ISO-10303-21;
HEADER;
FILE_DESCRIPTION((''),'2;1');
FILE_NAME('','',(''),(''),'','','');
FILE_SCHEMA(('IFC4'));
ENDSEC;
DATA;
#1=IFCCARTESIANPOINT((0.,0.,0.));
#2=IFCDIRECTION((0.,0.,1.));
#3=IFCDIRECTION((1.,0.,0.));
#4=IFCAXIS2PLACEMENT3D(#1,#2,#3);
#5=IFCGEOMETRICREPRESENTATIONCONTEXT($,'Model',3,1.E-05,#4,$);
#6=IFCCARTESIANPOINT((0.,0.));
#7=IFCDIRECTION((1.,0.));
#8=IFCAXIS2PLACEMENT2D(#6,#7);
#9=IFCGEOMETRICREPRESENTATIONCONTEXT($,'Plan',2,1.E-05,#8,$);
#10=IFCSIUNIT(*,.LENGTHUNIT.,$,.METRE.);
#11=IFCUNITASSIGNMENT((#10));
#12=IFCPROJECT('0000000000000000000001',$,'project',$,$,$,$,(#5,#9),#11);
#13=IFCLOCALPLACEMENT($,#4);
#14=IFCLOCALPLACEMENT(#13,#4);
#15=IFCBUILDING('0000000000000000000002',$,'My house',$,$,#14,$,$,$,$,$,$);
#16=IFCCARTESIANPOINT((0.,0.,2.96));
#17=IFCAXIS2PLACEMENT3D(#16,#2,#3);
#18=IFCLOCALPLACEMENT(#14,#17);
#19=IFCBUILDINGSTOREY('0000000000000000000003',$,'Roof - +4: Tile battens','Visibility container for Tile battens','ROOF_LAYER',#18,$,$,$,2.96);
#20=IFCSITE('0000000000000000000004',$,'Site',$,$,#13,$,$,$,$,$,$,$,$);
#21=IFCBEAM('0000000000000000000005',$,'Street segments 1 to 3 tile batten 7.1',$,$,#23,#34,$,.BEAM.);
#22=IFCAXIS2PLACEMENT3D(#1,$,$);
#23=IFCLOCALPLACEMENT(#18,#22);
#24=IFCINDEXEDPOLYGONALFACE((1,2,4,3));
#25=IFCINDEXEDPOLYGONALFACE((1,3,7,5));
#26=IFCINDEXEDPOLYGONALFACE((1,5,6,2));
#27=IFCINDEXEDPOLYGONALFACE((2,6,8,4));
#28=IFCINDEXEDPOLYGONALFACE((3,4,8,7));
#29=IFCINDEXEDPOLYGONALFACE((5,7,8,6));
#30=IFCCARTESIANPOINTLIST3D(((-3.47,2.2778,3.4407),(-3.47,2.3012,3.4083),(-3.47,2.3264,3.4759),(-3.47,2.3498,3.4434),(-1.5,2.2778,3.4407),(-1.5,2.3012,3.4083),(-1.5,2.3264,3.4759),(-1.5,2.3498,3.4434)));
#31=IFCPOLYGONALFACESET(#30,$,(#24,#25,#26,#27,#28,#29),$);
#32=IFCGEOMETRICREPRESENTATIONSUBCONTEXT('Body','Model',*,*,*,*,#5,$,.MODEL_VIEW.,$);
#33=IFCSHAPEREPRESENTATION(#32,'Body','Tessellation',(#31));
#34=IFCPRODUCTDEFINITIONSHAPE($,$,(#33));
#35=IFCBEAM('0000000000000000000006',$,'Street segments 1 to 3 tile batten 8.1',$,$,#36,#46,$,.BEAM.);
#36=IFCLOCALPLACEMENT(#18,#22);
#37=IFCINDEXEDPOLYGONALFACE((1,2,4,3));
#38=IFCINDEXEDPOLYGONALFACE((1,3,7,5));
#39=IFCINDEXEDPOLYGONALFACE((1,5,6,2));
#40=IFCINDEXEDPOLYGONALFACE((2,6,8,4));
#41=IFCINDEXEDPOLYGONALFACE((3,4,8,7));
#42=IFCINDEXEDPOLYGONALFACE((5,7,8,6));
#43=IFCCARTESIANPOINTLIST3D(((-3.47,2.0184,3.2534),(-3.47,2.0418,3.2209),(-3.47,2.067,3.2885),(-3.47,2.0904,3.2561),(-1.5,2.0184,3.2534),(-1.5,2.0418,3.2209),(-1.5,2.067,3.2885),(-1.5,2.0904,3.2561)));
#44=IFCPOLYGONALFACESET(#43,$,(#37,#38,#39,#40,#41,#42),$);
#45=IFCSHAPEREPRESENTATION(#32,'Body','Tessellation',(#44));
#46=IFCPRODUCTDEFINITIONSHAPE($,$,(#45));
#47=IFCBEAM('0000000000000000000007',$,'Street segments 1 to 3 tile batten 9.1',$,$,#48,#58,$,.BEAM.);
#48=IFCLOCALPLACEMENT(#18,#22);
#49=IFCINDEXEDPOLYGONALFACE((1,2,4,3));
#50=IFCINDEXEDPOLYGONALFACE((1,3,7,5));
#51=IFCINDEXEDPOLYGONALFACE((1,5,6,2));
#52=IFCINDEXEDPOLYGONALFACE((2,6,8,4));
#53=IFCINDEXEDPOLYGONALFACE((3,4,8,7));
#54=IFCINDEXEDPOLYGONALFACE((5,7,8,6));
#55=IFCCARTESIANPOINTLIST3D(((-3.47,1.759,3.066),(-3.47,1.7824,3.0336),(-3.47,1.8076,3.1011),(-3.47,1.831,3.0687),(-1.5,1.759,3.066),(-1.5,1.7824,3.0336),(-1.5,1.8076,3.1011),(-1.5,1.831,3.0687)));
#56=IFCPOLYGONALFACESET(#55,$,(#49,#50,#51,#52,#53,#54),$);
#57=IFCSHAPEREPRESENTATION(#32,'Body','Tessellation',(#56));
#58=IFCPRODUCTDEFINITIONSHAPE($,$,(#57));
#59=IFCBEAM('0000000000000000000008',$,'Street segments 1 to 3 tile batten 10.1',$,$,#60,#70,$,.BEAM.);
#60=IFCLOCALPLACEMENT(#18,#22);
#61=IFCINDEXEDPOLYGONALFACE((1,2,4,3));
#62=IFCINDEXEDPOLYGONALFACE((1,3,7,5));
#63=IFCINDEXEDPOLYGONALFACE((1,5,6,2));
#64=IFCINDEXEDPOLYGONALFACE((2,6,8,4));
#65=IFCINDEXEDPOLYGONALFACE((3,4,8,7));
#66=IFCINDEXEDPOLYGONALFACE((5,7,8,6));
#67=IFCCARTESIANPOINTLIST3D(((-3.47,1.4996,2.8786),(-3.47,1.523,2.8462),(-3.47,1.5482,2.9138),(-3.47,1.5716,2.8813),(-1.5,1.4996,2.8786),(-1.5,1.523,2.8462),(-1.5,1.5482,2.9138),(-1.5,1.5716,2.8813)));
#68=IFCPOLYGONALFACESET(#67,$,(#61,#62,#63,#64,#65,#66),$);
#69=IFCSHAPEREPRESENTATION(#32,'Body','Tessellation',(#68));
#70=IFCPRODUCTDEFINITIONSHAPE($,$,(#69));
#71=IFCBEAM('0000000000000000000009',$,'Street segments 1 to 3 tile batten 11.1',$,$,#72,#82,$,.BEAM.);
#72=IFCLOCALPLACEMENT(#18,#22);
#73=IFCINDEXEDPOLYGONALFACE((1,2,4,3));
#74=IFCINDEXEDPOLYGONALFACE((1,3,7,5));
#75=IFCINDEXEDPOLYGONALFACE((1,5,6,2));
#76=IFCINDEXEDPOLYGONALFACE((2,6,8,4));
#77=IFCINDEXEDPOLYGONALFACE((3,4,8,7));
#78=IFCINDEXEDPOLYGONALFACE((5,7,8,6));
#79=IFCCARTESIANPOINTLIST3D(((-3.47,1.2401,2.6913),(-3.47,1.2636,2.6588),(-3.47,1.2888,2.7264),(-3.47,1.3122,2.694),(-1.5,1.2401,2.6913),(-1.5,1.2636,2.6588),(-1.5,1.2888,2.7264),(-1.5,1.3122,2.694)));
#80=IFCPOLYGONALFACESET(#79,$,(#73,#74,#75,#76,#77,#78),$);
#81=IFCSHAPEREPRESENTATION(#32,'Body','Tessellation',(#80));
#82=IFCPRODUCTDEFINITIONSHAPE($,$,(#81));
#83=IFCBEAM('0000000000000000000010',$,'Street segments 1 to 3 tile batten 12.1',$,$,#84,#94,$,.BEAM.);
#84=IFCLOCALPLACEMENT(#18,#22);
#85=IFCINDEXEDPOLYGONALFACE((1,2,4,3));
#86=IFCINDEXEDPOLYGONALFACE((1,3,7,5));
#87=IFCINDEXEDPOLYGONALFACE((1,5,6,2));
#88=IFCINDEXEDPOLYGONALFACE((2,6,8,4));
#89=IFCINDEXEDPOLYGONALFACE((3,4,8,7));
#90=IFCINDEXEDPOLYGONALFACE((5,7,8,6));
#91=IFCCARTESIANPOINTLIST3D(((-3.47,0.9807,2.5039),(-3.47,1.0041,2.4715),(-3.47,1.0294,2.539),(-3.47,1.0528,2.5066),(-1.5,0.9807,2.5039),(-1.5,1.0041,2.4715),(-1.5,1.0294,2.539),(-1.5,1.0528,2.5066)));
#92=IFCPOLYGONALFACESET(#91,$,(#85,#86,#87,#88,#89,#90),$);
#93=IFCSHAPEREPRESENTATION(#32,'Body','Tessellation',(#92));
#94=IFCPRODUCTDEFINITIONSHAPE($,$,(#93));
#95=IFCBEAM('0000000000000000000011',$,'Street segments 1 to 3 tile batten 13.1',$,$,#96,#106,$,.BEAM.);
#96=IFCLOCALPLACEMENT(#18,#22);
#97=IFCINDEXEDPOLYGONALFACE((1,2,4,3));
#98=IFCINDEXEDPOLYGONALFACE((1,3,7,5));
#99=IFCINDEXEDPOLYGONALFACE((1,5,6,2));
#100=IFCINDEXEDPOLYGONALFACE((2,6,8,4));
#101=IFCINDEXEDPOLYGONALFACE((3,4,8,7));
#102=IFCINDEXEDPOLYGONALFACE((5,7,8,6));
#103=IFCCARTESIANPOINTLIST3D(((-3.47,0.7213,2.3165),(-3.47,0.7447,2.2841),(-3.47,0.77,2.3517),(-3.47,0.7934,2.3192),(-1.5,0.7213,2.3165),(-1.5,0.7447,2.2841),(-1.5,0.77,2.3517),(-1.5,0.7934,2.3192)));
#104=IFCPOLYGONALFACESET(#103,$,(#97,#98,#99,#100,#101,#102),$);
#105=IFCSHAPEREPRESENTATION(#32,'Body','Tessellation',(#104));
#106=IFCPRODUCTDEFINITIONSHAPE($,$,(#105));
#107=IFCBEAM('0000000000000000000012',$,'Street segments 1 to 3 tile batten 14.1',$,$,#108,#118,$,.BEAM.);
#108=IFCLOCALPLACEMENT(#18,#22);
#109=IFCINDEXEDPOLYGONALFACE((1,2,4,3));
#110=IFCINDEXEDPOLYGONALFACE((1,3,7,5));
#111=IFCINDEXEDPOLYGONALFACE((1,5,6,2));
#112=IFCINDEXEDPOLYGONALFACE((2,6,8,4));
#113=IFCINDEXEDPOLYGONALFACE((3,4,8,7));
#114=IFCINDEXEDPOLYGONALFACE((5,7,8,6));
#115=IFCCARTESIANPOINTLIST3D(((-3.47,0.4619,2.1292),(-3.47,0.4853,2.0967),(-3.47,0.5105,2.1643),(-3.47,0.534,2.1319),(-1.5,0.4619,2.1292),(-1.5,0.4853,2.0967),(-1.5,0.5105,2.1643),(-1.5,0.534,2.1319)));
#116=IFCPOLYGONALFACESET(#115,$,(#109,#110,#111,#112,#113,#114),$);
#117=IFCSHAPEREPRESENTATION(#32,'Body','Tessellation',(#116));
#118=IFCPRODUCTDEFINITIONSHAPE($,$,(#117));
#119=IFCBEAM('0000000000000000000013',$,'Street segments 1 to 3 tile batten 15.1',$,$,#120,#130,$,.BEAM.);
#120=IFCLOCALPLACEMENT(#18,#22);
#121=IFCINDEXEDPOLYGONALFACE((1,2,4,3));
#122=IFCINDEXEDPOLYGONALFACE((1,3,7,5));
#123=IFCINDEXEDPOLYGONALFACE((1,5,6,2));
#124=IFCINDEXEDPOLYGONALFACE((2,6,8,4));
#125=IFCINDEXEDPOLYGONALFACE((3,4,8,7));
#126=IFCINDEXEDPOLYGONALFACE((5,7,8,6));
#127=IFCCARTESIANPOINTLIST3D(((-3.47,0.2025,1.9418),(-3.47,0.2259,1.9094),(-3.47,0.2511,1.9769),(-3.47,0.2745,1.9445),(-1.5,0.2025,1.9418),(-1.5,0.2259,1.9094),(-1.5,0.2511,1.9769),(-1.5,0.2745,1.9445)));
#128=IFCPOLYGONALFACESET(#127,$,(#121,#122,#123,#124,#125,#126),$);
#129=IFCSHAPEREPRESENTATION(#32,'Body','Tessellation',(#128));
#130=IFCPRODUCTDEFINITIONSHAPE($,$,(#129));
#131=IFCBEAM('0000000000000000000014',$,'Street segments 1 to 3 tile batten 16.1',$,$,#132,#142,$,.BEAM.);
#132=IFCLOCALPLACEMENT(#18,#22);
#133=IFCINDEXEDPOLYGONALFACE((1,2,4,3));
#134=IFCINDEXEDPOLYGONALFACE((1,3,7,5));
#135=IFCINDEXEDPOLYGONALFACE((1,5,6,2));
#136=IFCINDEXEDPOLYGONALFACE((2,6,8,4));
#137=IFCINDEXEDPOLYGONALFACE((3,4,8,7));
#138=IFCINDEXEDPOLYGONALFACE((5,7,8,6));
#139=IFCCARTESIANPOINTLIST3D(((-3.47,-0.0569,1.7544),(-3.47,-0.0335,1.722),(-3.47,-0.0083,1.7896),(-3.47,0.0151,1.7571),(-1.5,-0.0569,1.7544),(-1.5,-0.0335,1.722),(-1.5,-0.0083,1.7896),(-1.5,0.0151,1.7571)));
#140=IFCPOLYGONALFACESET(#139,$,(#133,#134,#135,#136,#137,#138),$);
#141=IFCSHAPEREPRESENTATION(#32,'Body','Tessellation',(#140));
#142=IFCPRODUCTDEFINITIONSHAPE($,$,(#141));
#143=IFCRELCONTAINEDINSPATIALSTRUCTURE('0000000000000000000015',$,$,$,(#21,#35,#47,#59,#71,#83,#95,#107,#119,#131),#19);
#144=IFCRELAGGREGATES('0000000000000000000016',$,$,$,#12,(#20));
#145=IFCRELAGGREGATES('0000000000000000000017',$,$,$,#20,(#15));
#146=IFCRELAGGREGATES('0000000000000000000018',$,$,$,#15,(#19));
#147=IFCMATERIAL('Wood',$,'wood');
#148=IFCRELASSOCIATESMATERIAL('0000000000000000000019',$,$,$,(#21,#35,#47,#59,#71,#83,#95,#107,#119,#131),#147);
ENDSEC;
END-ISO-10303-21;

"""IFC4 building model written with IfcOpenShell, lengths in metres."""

from ifc_helpers import new_model, si_unit, frame, origin_with_axes, origin_2d_with_axis, place, context, subcontext, project, spatial, rectangle, extrude, clip, halfspace, source, transform, mapped, material, element, save


model = new_model("IFC4")

# Units and contexts
model_context = context("Model", 3, precision=1e-05, world=origin_with_axes())
plan_context = context("Plan", 2, precision=1e-05, world=origin_2d_with_axis())
body_context = subcontext(model_context, "Body", "Model", "MODEL_VIEW")
ifc_project = project(units=[si_unit("LENGTHUNIT", "METRE")], contexts=[model_context, plan_context])

# Site, building, storey
site_placement = place(None, origin_with_axes())
site = spatial("IfcSite", under=ifc_project, at=site_placement, Name="Site")
building_placement = place(site_placement, origin_with_axes())
building = spatial("IfcBuilding", under=site, at=building_placement, Name="My house")
storey_placement = place(building_placement, frame((0.0, 0.0, 2.96), z_axis=(0.0, 0.0, 1.0), x_axis=(1.0, 0.0, 0.0)))
storey = spatial("IfcBuildingStorey", under=building, at=storey_placement, Name="Roof - +4: Tile battens", Description="Visibility container for Tile battens", ObjectType="ROOF_LAYER", Elevation=2.96)

# Beams
ifc_material = material(Name="Wood", Category="wood")
shared_shape_1 = source(origin_with_axes(), body_context, "Body", "Clipping", [
    clip(clip(extrude(rectangle(XDim=0.06, YDim=0.04), frame((0.0, 0.0, 0.0), z_axis=(1.0, 0.0, 0.0), x_axis=(0.0, 1.0, 0.0)), (0.0, 0.0, 1.0), 1.97), halfspace(frame((-1.5, -2.3816, -6.1772), z_axis=(0.0, 0.810664, -0.585512), x_axis=(1.0, 0.0, 0.0)), False)), halfspace(frame((-1.5, -6.2322, -3.396), z_axis=(0.0, -0.810664, 0.585512), x_axis=(-1.0, 0.0, 0.0)), False)),
])
beam_1_placement = place(storey_placement, frame((-1.5, 2.3138, 3.4421), z_axis=(0.0, -0.585512, 0.810664), x_axis=(1.0, 0.0, 0.0)))
element("IfcBeam", 1, at=beam_1_placement, inside=storey, material=ifc_material, Name="Street segments 1 to 3 tile batten 7.1", PredefinedType="BEAM", context=body_context, shape_type="MappedRepresentation", body=[
    mapped(shared_shape_1, transform((0.0, 0.0, 0.0), x_axis=(-1.0, 0.0, 0.0), y_axis=(0.0, 1.0, 0.0), z_axis=(0.0, 0.0, 1.0), scale=1.0)),
])
shared_shape_2 = source(origin_with_axes(), body_context, "Body", "Clipping", [
    clip(clip(extrude(rectangle(XDim=0.06, YDim=0.04), frame((0.0, 0.0, 0.0), z_axis=(1.0, 0.0, 0.0), x_axis=(0.0, 1.0, 0.0)), (0.0, 0.0, 1.0), 1.97), halfspace(frame((-1.5, -2.0616, -6.1772), z_axis=(0.0, 0.810664, -0.585512), x_axis=(1.0, 0.0, 0.0)), False)), halfspace(frame((-1.5, -5.9122, -3.396), z_axis=(0.0, -0.810664, 0.585512), x_axis=(-1.0, 0.0, 0.0)), False)),
])
beam_2_placement = place(storey_placement, frame((-1.5, 2.0544, 3.2547), z_axis=(0.0, -0.585512, 0.810664), x_axis=(1.0, 0.0, 0.0)))
element("IfcBeam", 2, at=beam_2_placement, inside=storey, material=ifc_material, Name="Street segments 1 to 3 tile batten 8.1", PredefinedType="BEAM", context=body_context, shape_type="MappedRepresentation", body=[
    mapped(shared_shape_2, transform((0.0, 0.0, 0.0), x_axis=(-1.0, 0.0, 0.0), y_axis=(0.0, 1.0, 0.0), z_axis=(0.0, 0.0, 1.0), scale=1.0)),
])
shared_shape_3 = source(origin_with_axes(), body_context, "Body", "Clipping", [
    clip(clip(extrude(rectangle(XDim=0.06, YDim=0.04), frame((0.0, 0.0, 0.0), z_axis=(1.0, 0.0, 0.0), x_axis=(0.0, 1.0, 0.0)), (0.0, 0.0, 1.0), 1.97), halfspace(frame((-1.5, -1.7416, -6.1772), z_axis=(0.0, 0.810664, -0.585512), x_axis=(1.0, 0.0, 0.0)), False)), halfspace(frame((-1.5, -5.5922, -3.396), z_axis=(0.0, -0.810664, 0.585512), x_axis=(-1.0, 0.0, 0.0)), False)),
])
beam_3_placement = place(storey_placement, frame((-1.5, 1.795, 3.0673), z_axis=(0.0, -0.585512, 0.810664), x_axis=(1.0, 0.0, 0.0)))
element("IfcBeam", 3, at=beam_3_placement, inside=storey, material=ifc_material, Name="Street segments 1 to 3 tile batten 9.1", PredefinedType="BEAM", context=body_context, shape_type="MappedRepresentation", body=[
    mapped(shared_shape_3, transform((0.0, 0.0, 0.0), x_axis=(-1.0, 0.0, 0.0), y_axis=(0.0, 1.0, 0.0), z_axis=(0.0, 0.0, 1.0), scale=1.0)),
])
shared_shape_4 = source(origin_with_axes(), body_context, "Body", "Clipping", [
    clip(clip(extrude(rectangle(XDim=0.06, YDim=0.04), frame((0.0, 0.0, 0.0), z_axis=(1.0, 0.0, 0.0), x_axis=(0.0, 1.0, 0.0)), (0.0, 0.0, 1.0), 1.97), halfspace(frame((-1.5, -1.4216, -6.1772), z_axis=(0.0, 0.810664, -0.585512), x_axis=(1.0, 0.0, 0.0)), False)), halfspace(frame((-1.5, -5.2722, -3.396), z_axis=(0.0, -0.810664, 0.585512), x_axis=(-1.0, 0.0, 0.0)), False)),
])
beam_4_placement = place(storey_placement, frame((-1.5, 1.5356, 2.88), z_axis=(0.0, -0.585512, 0.810664), x_axis=(1.0, 0.0, 0.0)))
element("IfcBeam", 4, at=beam_4_placement, inside=storey, material=ifc_material, Name="Street segments 1 to 3 tile batten 10.1", PredefinedType="BEAM", context=body_context, shape_type="MappedRepresentation", body=[
    mapped(shared_shape_4, transform((0.0, 0.0, 0.0), x_axis=(-1.0, 0.0, 0.0), y_axis=(0.0, 1.0, 0.0), z_axis=(0.0, 0.0, 1.0), scale=1.0)),
])
shared_shape_5 = source(origin_with_axes(), body_context, "Body", "Clipping", [
    clip(clip(extrude(rectangle(XDim=0.06, YDim=0.04), frame((0.0, 0.0, 0.0), z_axis=(1.0, 0.0, 0.0), x_axis=(0.0, 1.0, 0.0)), (0.0, 0.0, 1.0), 1.97), halfspace(frame((-1.5, -1.1016, -6.1772), z_axis=(0.0, 0.810664, -0.585512), x_axis=(1.0, 0.0, 0.0)), False)), halfspace(frame((-1.5, -4.9522, -3.396), z_axis=(0.0, -0.810664, 0.585512), x_axis=(-1.0, 0.0, 0.0)), False)),
])
beam_5_placement = place(storey_placement, frame((-1.5, 1.2762, 2.6926), z_axis=(0.0, -0.585512, 0.810664), x_axis=(1.0, 0.0, 0.0)))
element("IfcBeam", 5, at=beam_5_placement, inside=storey, material=ifc_material, Name="Street segments 1 to 3 tile batten 11.1", PredefinedType="BEAM", context=body_context, shape_type="MappedRepresentation", body=[
    mapped(shared_shape_5, transform((0.0, 0.0, 0.0), x_axis=(-1.0, 0.0, 0.0), y_axis=(0.0, 1.0, 0.0), z_axis=(0.0, 0.0, 1.0), scale=1.0)),
])
shared_shape_6 = source(origin_with_axes(), body_context, "Body", "Clipping", [
    clip(clip(extrude(rectangle(XDim=0.06, YDim=0.04), frame((0.0, 0.0, 0.0), z_axis=(1.0, 0.0, 0.0), x_axis=(0.0, 1.0, 0.0)), (0.0, 0.0, 1.0), 1.97), halfspace(frame((-1.5, -0.7816, -6.1772), z_axis=(0.0, 0.810664, -0.585512), x_axis=(1.0, 0.0, 0.0)), False)), halfspace(frame((-1.5, -4.6322, -3.396), z_axis=(0.0, -0.810664, 0.585512), x_axis=(-1.0, 0.0, 0.0)), False)),
])
beam_6_placement = place(storey_placement, frame((-1.5, 1.0168, 2.5053), z_axis=(0.0, -0.585512, 0.810664), x_axis=(1.0, 0.0, 0.0)))
element("IfcBeam", 6, at=beam_6_placement, inside=storey, material=ifc_material, Name="Street segments 1 to 3 tile batten 12.1", PredefinedType="BEAM", context=body_context, shape_type="MappedRepresentation", body=[
    mapped(shared_shape_6, transform((0.0, 0.0, 0.0), x_axis=(-1.0, 0.0, 0.0), y_axis=(0.0, 1.0, 0.0), z_axis=(0.0, 0.0, 1.0), scale=1.0)),
])
shared_shape_7 = source(origin_with_axes(), body_context, "Body", "Clipping", [
    clip(clip(extrude(rectangle(XDim=0.06, YDim=0.04), frame((0.0, 0.0, 0.0), z_axis=(1.0, 0.0, 0.0), x_axis=(0.0, 1.0, 0.0)), (0.0, 0.0, 1.0), 1.97), halfspace(frame((-1.5, -0.4616, -6.1772), z_axis=(0.0, 0.810664, -0.585512), x_axis=(1.0, 0.0, 0.0)), False)), halfspace(frame((-1.5, -4.3122, -3.396), z_axis=(0.0, -0.810664, 0.585512), x_axis=(-1.0, 0.0, 0.0)), False)),
])
beam_7_placement = place(storey_placement, frame((-1.5, 0.7573, 2.3179), z_axis=(0.0, -0.585512, 0.810664), x_axis=(1.0, 0.0, 0.0)))
element("IfcBeam", 7, at=beam_7_placement, inside=storey, material=ifc_material, Name="Street segments 1 to 3 tile batten 13.1", PredefinedType="BEAM", context=body_context, shape_type="MappedRepresentation", body=[
    mapped(shared_shape_7, transform((0.0, 0.0, 0.0), x_axis=(-1.0, 0.0, 0.0), y_axis=(0.0, 1.0, 0.0), z_axis=(0.0, 0.0, 1.0), scale=1.0)),
])
shared_shape_8 = source(origin_with_axes(), body_context, "Body", "Clipping", [
    clip(clip(extrude(rectangle(XDim=0.06, YDim=0.04), frame((0.0, 0.0, 0.0), z_axis=(1.0, 0.0, 0.0), x_axis=(0.0, 1.0, 0.0)), (0.0, 0.0, 1.0), 1.97), halfspace(frame((-1.5, -0.1416, -6.1772), z_axis=(0.0, 0.810664, -0.585512), x_axis=(1.0, 0.0, 0.0)), False)), halfspace(frame((-1.5, -3.9922, -3.396), z_axis=(0.0, -0.810664, 0.585512), x_axis=(-1.0, 0.0, 0.0)), False)),
])
beam_8_placement = place(storey_placement, frame((-1.5, 0.4979, 2.1305), z_axis=(0.0, -0.585512, 0.810664), x_axis=(1.0, 0.0, 0.0)))
element("IfcBeam", 8, at=beam_8_placement, inside=storey, material=ifc_material, Name="Street segments 1 to 3 tile batten 14.1", PredefinedType="BEAM", context=body_context, shape_type="MappedRepresentation", body=[
    mapped(shared_shape_8, transform((0.0, 0.0, 0.0), x_axis=(-1.0, 0.0, 0.0), y_axis=(0.0, 1.0, 0.0), z_axis=(0.0, 0.0, 1.0), scale=1.0)),
])
shared_shape_9 = source(origin_with_axes(), body_context, "Body", "Clipping", [
    clip(clip(extrude(rectangle(XDim=0.06, YDim=0.04), frame((0.0, 0.0, 0.0), z_axis=(1.0, 0.0, 0.0), x_axis=(0.0, 1.0, 0.0)), (0.0, 0.0, 1.0), 1.97), halfspace(frame((-1.5, 0.1784, -6.1772), z_axis=(0.0, 0.810664, -0.585512), x_axis=(1.0, 0.0, 0.0)), False)), halfspace(frame((-1.5, -3.6722, -3.396), z_axis=(0.0, -0.810664, 0.585512), x_axis=(-1.0, 0.0, 0.0)), False)),
])
beam_9_placement = place(storey_placement, frame((-1.5, 0.2385, 1.9432), z_axis=(0.0, -0.585512, 0.810664), x_axis=(1.0, 0.0, 0.0)))
element("IfcBeam", 9, at=beam_9_placement, inside=storey, material=ifc_material, Name="Street segments 1 to 3 tile batten 15.1", PredefinedType="BEAM", context=body_context, shape_type="MappedRepresentation", body=[
    mapped(shared_shape_9, transform((0.0, 0.0, 0.0), x_axis=(-1.0, 0.0, 0.0), y_axis=(0.0, 1.0, 0.0), z_axis=(0.0, 0.0, 1.0), scale=1.0)),
])
shared_shape_10 = source(origin_with_axes(), body_context, "Body", "Clipping", [
    clip(clip(extrude(rectangle(XDim=0.06, YDim=0.04), frame((0.0, 0.0, 0.0), z_axis=(1.0, 0.0, 0.0), x_axis=(0.0, 1.0, 0.0)), (0.0, 0.0, 1.0), 1.97), halfspace(frame((-1.5, 0.4984, -6.1772), z_axis=(0.0, 0.810664, -0.585512), x_axis=(1.0, 0.0, 0.0)), False)), halfspace(frame((-1.5, -3.3522, -3.396), z_axis=(0.0, -0.810664, 0.585512), x_axis=(-1.0, 0.0, 0.0)), False)),
])
beam_10_placement = place(storey_placement, frame((-1.5, -0.0209, 1.7558), z_axis=(0.0, -0.585512, 0.810664), x_axis=(1.0, 0.0, 0.0)))
element("IfcBeam", 10, at=beam_10_placement, inside=storey, material=ifc_material, Name="Street segments 1 to 3 tile batten 16.1", PredefinedType="BEAM", context=body_context, shape_type="MappedRepresentation", body=[
    mapped(shared_shape_10, transform((0.0, 0.0, 0.0), x_axis=(-1.0, 0.0, 0.0), y_axis=(0.0, 1.0, 0.0), z_axis=(0.0, 0.0, 1.0), scale=1.0)),
])

save(model, "model.ifc")
